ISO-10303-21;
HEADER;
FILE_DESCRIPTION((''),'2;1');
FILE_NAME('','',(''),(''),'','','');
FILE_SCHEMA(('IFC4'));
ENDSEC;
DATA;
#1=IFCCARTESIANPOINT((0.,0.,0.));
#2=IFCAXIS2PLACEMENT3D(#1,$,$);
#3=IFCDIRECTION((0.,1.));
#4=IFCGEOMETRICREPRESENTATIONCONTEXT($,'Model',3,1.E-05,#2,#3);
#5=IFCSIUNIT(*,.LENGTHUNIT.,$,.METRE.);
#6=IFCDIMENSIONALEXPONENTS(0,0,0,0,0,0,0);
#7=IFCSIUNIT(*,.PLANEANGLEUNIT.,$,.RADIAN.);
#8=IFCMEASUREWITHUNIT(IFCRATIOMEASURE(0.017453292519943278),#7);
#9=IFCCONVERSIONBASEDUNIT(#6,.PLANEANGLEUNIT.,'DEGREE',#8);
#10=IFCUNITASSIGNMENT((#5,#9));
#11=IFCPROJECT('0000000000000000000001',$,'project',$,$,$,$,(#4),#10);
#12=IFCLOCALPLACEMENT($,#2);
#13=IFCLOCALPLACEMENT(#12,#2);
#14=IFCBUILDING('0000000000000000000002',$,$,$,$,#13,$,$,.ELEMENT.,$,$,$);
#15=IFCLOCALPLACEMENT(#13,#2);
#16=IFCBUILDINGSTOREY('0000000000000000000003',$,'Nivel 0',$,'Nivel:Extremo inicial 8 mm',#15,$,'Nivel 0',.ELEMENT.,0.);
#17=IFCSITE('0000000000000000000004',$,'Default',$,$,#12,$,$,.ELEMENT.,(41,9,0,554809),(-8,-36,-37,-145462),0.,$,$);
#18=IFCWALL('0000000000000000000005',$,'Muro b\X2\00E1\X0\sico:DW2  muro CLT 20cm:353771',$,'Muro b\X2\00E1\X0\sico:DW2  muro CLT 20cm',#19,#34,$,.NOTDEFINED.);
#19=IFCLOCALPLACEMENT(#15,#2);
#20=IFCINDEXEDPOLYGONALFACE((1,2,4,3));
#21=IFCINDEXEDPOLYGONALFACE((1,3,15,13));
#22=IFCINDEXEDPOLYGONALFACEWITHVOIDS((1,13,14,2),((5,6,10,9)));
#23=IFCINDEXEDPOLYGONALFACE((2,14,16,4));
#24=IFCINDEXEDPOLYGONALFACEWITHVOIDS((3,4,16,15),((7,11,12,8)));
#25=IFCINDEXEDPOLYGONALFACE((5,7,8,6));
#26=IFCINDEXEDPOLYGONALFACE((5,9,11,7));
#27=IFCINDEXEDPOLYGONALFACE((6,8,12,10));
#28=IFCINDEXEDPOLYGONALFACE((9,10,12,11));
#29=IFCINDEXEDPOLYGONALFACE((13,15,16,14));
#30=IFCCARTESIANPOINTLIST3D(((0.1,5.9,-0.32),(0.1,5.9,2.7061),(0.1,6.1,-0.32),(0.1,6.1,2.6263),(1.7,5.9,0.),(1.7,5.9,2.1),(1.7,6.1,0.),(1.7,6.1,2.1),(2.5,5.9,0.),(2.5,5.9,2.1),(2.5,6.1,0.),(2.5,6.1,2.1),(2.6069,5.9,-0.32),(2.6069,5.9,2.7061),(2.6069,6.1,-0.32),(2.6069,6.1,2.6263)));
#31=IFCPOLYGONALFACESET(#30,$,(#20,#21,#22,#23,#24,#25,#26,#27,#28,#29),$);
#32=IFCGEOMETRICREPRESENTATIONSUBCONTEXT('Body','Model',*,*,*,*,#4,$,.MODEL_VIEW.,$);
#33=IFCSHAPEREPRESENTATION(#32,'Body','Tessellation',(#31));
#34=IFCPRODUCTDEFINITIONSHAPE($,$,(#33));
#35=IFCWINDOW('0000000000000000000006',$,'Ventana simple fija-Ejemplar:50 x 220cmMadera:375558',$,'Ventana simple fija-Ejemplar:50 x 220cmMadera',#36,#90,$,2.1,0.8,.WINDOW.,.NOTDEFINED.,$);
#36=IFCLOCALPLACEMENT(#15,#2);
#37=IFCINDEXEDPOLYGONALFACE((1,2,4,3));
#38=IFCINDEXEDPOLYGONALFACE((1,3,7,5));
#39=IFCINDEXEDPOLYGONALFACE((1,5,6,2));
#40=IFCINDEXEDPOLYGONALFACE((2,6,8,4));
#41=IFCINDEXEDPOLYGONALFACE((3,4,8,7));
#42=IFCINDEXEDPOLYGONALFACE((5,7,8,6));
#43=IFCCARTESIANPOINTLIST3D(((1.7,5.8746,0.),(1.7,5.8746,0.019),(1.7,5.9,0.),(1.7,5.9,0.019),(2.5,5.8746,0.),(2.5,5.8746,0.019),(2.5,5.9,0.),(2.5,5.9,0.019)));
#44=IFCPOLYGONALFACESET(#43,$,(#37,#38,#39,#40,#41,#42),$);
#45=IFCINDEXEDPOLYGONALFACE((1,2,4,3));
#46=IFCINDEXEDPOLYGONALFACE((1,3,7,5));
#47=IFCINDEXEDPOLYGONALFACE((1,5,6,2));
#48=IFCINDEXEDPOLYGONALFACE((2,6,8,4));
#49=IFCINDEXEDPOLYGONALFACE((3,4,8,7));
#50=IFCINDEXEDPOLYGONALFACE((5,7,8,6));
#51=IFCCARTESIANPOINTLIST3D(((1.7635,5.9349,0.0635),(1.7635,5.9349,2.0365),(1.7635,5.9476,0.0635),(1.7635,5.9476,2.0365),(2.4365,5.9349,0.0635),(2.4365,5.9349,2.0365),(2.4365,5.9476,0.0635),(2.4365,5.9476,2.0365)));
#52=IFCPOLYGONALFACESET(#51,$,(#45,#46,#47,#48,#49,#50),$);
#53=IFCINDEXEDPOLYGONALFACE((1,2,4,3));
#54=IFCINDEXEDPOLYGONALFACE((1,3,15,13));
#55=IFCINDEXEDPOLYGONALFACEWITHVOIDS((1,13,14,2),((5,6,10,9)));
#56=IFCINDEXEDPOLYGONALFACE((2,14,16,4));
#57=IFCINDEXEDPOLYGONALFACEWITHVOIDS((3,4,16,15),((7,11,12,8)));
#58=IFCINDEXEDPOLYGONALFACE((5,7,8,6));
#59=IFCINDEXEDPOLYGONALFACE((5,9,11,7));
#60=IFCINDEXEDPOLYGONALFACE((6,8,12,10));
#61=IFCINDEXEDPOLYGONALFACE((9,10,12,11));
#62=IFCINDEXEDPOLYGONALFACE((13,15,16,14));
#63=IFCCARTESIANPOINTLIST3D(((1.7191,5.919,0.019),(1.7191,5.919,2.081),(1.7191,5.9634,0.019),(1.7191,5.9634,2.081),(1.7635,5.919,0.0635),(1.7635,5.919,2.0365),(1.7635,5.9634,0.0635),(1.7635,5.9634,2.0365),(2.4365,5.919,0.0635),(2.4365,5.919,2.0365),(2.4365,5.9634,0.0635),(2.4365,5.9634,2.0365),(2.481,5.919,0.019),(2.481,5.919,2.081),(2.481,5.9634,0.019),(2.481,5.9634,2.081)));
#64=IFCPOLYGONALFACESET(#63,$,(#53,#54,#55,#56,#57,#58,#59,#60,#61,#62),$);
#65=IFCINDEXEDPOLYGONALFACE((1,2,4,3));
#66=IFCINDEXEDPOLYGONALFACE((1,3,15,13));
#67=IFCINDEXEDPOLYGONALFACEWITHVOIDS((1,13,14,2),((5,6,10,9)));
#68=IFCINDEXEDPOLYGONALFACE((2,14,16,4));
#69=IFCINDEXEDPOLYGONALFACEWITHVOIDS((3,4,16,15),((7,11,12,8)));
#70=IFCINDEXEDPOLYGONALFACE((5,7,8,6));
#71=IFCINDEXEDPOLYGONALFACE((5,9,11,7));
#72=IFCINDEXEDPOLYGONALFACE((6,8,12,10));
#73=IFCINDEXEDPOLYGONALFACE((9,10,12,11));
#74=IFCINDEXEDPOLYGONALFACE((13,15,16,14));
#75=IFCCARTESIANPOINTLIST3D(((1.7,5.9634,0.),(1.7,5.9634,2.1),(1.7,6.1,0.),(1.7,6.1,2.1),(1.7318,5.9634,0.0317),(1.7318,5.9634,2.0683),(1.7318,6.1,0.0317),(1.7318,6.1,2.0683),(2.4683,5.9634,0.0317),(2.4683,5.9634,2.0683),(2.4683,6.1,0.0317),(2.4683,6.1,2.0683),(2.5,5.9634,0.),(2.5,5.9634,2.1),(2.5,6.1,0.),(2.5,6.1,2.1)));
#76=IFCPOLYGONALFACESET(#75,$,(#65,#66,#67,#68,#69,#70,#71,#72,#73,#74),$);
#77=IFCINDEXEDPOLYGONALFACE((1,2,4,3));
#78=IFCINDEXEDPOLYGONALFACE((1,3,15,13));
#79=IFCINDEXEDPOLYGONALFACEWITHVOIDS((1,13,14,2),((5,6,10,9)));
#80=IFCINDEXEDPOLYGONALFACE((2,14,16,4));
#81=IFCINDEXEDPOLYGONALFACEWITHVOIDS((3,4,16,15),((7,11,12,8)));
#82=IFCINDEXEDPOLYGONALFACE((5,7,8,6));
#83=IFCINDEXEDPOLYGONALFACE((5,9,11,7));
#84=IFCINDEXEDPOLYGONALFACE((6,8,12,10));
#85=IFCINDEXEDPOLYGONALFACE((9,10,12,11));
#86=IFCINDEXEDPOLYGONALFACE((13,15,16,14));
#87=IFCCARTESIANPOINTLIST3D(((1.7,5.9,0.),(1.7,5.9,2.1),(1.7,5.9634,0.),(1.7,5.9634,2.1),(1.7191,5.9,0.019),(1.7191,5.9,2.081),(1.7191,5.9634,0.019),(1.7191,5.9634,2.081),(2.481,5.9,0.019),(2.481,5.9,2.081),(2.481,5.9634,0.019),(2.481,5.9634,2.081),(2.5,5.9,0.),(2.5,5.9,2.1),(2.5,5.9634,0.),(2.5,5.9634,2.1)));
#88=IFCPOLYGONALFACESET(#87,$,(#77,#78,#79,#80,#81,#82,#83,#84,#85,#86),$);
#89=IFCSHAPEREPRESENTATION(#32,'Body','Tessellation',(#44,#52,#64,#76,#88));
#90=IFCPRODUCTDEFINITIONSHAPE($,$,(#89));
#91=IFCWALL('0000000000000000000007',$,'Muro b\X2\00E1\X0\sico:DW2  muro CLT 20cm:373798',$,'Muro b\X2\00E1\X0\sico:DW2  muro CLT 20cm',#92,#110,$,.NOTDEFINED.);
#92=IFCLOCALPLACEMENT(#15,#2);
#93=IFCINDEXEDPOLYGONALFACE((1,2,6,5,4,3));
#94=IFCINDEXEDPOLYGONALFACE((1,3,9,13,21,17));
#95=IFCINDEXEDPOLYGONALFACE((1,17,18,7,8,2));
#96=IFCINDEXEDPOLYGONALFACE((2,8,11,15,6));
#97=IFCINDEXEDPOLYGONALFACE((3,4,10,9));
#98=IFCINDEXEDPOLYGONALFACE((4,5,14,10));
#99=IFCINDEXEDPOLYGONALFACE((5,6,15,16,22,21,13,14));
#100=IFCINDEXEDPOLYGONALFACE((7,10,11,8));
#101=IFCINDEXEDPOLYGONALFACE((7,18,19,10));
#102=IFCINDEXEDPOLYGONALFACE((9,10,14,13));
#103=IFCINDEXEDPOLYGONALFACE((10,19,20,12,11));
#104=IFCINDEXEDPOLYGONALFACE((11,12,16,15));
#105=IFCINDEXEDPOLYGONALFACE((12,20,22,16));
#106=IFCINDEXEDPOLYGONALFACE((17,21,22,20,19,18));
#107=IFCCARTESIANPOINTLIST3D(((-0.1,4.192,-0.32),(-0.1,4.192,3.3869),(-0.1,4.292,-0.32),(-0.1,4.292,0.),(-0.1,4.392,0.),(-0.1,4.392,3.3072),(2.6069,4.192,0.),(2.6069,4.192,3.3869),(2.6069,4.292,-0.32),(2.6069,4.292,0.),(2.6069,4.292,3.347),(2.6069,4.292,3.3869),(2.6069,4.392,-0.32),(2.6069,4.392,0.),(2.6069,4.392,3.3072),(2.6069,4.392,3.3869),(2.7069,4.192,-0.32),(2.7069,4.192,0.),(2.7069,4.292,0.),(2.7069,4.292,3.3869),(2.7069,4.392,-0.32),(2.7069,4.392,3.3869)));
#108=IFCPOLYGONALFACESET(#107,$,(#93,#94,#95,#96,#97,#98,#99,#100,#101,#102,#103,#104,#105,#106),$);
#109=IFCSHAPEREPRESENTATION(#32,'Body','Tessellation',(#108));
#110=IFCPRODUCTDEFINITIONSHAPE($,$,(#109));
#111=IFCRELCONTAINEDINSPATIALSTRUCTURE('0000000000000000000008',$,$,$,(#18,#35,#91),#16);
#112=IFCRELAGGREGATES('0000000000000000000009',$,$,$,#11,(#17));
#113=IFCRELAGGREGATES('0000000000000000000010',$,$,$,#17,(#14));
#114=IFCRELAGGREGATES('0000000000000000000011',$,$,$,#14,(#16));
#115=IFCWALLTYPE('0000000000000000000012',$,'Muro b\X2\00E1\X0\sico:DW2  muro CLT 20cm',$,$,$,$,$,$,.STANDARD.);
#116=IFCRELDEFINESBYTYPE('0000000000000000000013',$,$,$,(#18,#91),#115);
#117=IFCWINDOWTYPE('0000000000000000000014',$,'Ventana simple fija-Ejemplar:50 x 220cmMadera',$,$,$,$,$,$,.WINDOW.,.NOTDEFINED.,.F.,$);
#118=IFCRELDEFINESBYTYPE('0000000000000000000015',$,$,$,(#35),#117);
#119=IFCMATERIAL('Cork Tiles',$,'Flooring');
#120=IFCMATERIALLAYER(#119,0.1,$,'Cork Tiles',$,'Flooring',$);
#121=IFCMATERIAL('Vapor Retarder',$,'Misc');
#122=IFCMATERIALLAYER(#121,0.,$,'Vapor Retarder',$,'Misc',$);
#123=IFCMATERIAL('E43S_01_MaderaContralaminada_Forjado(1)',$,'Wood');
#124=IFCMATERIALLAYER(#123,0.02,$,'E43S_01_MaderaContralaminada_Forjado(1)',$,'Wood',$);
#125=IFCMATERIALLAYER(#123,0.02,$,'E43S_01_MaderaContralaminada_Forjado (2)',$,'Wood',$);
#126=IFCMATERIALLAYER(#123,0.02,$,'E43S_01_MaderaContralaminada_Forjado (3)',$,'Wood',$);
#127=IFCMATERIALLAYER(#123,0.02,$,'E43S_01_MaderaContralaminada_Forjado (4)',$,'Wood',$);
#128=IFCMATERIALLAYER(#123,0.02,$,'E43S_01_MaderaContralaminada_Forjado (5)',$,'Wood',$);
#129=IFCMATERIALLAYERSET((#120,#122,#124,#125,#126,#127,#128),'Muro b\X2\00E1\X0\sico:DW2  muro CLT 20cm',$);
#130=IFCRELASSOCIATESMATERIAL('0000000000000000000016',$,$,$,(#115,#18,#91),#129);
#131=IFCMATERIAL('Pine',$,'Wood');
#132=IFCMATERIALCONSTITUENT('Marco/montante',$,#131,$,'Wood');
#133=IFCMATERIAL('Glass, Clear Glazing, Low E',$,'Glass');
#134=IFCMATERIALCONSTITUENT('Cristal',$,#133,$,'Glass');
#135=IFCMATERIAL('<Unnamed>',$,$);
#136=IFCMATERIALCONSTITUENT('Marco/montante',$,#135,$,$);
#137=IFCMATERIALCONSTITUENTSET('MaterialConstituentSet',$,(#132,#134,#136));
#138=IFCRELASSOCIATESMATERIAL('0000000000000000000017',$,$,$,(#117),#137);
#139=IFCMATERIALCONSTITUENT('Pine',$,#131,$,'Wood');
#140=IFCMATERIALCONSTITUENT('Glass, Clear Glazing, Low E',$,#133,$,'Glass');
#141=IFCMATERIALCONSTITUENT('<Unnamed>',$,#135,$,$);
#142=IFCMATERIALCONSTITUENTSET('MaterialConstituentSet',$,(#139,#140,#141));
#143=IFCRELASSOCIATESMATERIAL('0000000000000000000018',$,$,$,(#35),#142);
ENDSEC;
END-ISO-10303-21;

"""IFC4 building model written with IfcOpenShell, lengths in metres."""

from ifc_helpers import new_model, entity, si_unit, converted_unit, direction, frame, frame_2d, origin, origin_2d_with_axis, place, context, subcontext, project, spatial, polyline, rectangle, outline, extrude, clip, bounded_halfspace, source, transform, mapped, material, layer, layer_set, layer_usage, constituent, constituent_set, type_object, type_shapes, element, fill, save


model = new_model("IFC4")

# Units and contexts
model_context = context("Model", 3, precision=1e-05, world=origin(), true_north=direction((0.0, 1.0)))
body_context = subcontext(model_context, "Body", "Model", "MODEL_VIEW")
ifc_project = project(units=[si_unit("LENGTHUNIT", "METRE"), converted_unit("PLANEANGLEUNIT", "DEGREE", entity("IfcRatioMeasure", 0.017453292519943278), si_unit("PLANEANGLEUNIT", "RADIAN"), dimensions=[0, 0, 0, 0, 0, 0, 0])], contexts=[model_context])

# Site, building, storey
site_placement = place(None, origin())
site = spatial("IfcSite", under=ifc_project, at=site_placement, Name="Default", CompositionType="ELEMENT", RefLatitude=(41, 9, 0, 554809), RefLongitude=(-8, -36, -37, -145462), RefElevation=0.0)
building_placement = place(site_placement, origin())
building = spatial("IfcBuilding", under=site, at=building_placement, CompositionType="ELEMENT")
storey_placement = place(building_placement, origin())
storey = spatial("IfcBuildingStorey", under=building, at=storey_placement, Name="Nivel 0", ObjectType="Nivel:Extremo inicial 8 mm", LongName="Nivel 0", CompositionType="ELEMENT", Elevation=0.0)

# Shared definitions
ifc_material_1 = material(Name="E43S_01_MaderaContralaminada_Forjado(1)", Category="Wood")
ifc_material_2 = material(Name="Cork Tiles", Category="Flooring")

# Shared definitions
ifc_material_3 = material(Name="Vapor Retarder", Category="Misc")

# Wall, opening, window
ifc_layer_1 = layer(ifc_material_2, 0.1, Name="Cork Tiles", Category="Flooring")
ifc_layer_2 = layer(ifc_material_3, 0.0, Name="Vapor Retarder", Category="Misc")
ifc_layer_3 = layer(ifc_material_1, 0.02, Name="E43S_01_MaderaContralaminada_Forjado(1)", Category="Wood")
ifc_layer_4 = layer(ifc_material_1, 0.02, Name="E43S_01_MaderaContralaminada_Forjado (2)", Category="Wood")
ifc_layer_5 = layer(ifc_material_1, 0.02, Name="E43S_01_MaderaContralaminada_Forjado (3)", Category="Wood")
ifc_layer_6 = layer(ifc_material_1, 0.02, Name="E43S_01_MaderaContralaminada_Forjado (4)", Category="Wood")
ifc_layer_7 = layer(ifc_material_1, 0.02, Name="E43S_01_MaderaContralaminada_Forjado (5)", Category="Wood")
ifc_layer_set_1 = layer_set([ifc_layer_1, ifc_layer_2, ifc_layer_3, ifc_layer_4, ifc_layer_5, ifc_layer_6, ifc_layer_7], Name="Muro básico:DW2  muro CLT 20cm")
ifc_layer_usage_1 = layer_usage(ifc_layer_set_1, "AXIS2", "NEGATIVE", 0.1)
wall_type_1 = type_object("IfcWallType", Name="Muro básico:DW2  muro CLT 20cm", PredefinedType="STANDARD", material=ifc_layer_set_1)
wall_1_placement = place(storey_placement, frame((0.1, 6.0, -0.32)))
wall_1 = element("IfcWall", 1, at=wall_1_placement, inside=storey, type_object=wall_type_1, material=ifc_layer_usage_1, Name="Muro básico:DW2  muro CLT 20cm:353771", ObjectType="Muro básico:DW2  muro CLT 20cm", PredefinedType="NOTDEFINED", context=body_context, shape_type="Clipping", body=[
    clip(clip(extrude(rectangle(XDim=2.5069, YDim=0.2, at=frame_2d((1.2535, 0.0), x_axis=(1.0, 0.0))), origin(), (0.0, 0.0, 1.0), 3.0261), bounded_halfspace(frame((0.0, -0.1, 3.0261), z_axis=(0.0, 0.370288, 0.928917), x_axis=(-1.0, 0.0, 0.0)), False, frame((0.0, -0.1, 3.0261)), polyline([(0.0, 0.0), (2.5069, 0.0), (2.5069, 0.2), (0.0, 0.2), (0.0, 0.0)]))), bounded_halfspace(frame((2.6069, 0.1, 0.32), z_axis=(0.0, 0.0, 1.0), x_axis=(-1.0, 0.0, 0.0)), False, frame((2.6069, 0.1, 0.32)), polyline([(0.0, 0.0), (-0.1, 0.0), (-0.1, -0.1), (0.0, -0.1), (0.0, 0.0)]))),
])
opening_1_placement = place(wall_1_placement, frame((2.4, 0.1, 0.32)))
opening_1 = element("IfcOpeningElement", 2, at=opening_1_placement, cuts=wall_1, PredefinedType="OPENING", context=body_context, shape_type="SweptSolid", body=[
    extrude(rectangle(XDim=2.1, YDim=0.8, at=frame_2d((1.05, 0.4), x_axis=(-1.0, 0.0))), frame((0.0, 0.0, 0.0), z_axis=(0.0, -1.0, 0.0), x_axis=(0.0, 0.0, 1.0)), (0.0, 0.0, 1.0), 0.2),
])
ifc_material_4 = material(Name="Pine", Category="Wood")
ifc_constituent_1 = constituent(ifc_material_4, Name="Pine", Category="Wood")
ifc_material_5 = material(Name="Glass, Clear Glazing, Low E", Category="Glass")
ifc_constituent_2 = constituent(ifc_material_5, Name="Glass, Clear Glazing, Low E", Category="Glass")
ifc_material_6 = material(Name="<Unnamed>")
ifc_constituent_3 = constituent(ifc_material_6, Name="<Unnamed>")
ifc_constituent_set_1 = constituent_set(constituents=[ifc_constituent_1, ifc_constituent_2, ifc_constituent_3], Name="MaterialConstituentSet")
ifc_constituent_4 = constituent(ifc_material_4, Name="Marco/montante", Category="Wood")
ifc_constituent_5 = constituent(ifc_material_5, Name="Cristal", Category="Glass")
ifc_constituent_6 = constituent(ifc_material_6, Name="Marco/montante")
ifc_constituent_set_2 = constituent_set(constituents=[ifc_constituent_4, ifc_constituent_5, ifc_constituent_6], Name="MaterialConstituentSet")
window_type_1 = type_object("IfcWindowType", Name="Ventana simple fija-Ejemplar:50 x 220cmMadera", ParameterTakesPrecedence=False, PartitioningType="NOTDEFINED", PredefinedType="WINDOW", material=ifc_constituent_set_2)
shared_shape_1 = source(origin(), body_context, "Body", "SweptSolid", [
    extrude(rectangle(XDim=0.8, YDim=0.0254, at=origin_2d_with_axis()), frame((0.4762, 0.2127, 0.0), z_axis=(0.0, 0.0, 1.0), x_axis=(-1.0, 0.0, 0.0)), (0.0, 0.0, 1.0), 0.019),
    extrude(rectangle(XDim=0.673, YDim=0.0127, at=frame_2d((0.0, 0.0), x_axis=(1.0, 0.0))), frame((0.4762, 0.1588, 0.0635)), (0.0, 0.0, 1.0), 1.973),
    extrude(outline(polyline([(-0.3809, -1.031), (0.3809, -1.031), (0.3809, 1.031), (-0.3809, 1.031), (-0.3809, -1.031)]), holes=[polyline([(-0.3365, -0.9865), (-0.3365, 0.9865), (0.3365, 0.9865), (0.3365, -0.9865), (-0.3365, -0.9865)])]), frame((0.4762, 0.181, 1.05), z_axis=(0.0, -1.0, 0.0), x_axis=(-1.0, 0.0, 0.0)), (0.0, 0.0, 1.0), 0.0444),
    extrude(outline(polyline([(-0.4, -1.05), (0.4, -1.05), (0.4, 1.05), (-0.4, 1.05), (-0.4, -1.05)]), holes=[polyline([(-0.3683, -1.0183), (-0.3683, 1.0183), (0.3682, 1.0183), (0.3682, -1.0183), (-0.3683, -1.0183)])]), frame((0.4762, 0.1365, 1.05), z_axis=(0.0, -1.0, 0.0), x_axis=(-1.0, 0.0, 0.0)), (0.0, 0.0, 1.0), 0.1365),
    extrude(outline(polyline([(-1.05, -0.4), (1.05, -0.4), (1.05, 0.4), (-1.05, 0.4), (-1.05, -0.4)]), holes=[polyline([(-1.031, -0.3809), (-1.031, 0.381), (1.031, 0.381), (1.031, -0.3809), (-1.031, -0.3809)])]), frame((0.4762, 0.2, 1.05), z_axis=(0.0, -1.0, 0.0), x_axis=(0.0, 0.0, -1.0)), (0.0, 0.0, 1.0), 0.0635),
])
type_shapes(window_type_1, [shared_shape_1])
window_1_placement = place(opening_1_placement, frame((0.0762, 0.0, 0.0), z_axis=(0.0, 0.0, 1.0), x_axis=(-1.0, 0.0, 0.0)))
window_1 = element("IfcWindow", 3, at=window_1_placement, inside=storey, type_object=window_type_1, material=ifc_constituent_set_1, Name="Ventana simple fija-Ejemplar:50 x 220cmMadera:375558", ObjectType="Ventana simple fija-Ejemplar:50 x 220cmMadera", OverallHeight=2.1, OverallWidth=0.8, PartitioningType="NOTDEFINED", PredefinedType="WINDOW", context=body_context, shape_type="MappedRepresentation", body=[
    mapped(shared_shape_1, transform((0.0, 0.0, 0.0), scale=1.0)),
])
fill(opening_1, window_1)

# Wall
ifc_layer_usage_2 = layer_usage(ifc_layer_set_1, "AXIS2", "NEGATIVE", 0.1)
wall_2_placement = place(storey_placement, frame((2.7069, 4.292, -0.32), z_axis=(0.0, 0.0, 1.0), x_axis=(-1.0, 0.0, 0.0)))
element("IfcWall", 4, at=wall_2_placement, inside=storey, type_object=wall_type_1, material=ifc_layer_usage_2, Name="Muro básico:DW2  muro CLT 20cm:373798", ObjectType="Muro básico:DW2  muro CLT 20cm", PredefinedType="NOTDEFINED", context=body_context, shape_type="Clipping", body=[
    clip(clip(clip(extrude(rectangle(XDim=2.8069, YDim=0.2, at=frame_2d((1.4035, 0.0), x_axis=(-1.0, 0.0))), origin(), (0.0, 0.0, 1.0), 3.7069), bounded_halfspace(frame((0.1, -0.1, 3.6272), z_axis=(0.0, -0.370288, 0.928917), x_axis=(1.0, 0.0, 0.0)), False, frame((0.1, -0.1, 3.6272)), polyline([(0.0, 0.0), (2.5069, 0.0), (2.7069, 0.0), (2.7069, 0.2), (0.0, 0.2), (0.0, 0.0)]))), bounded_halfspace(frame((2.8069, -0.1, 0.32), z_axis=(0.0, 0.0, -1.0), x_axis=(0.0, 1.0, 0.0)), False, frame((2.8069, -0.1, 0.32)), polyline([(0.0, 0.0), (0.0, 0.1), (-0.1, 0.1), (-2.7069, 0.1), (-2.7069, 0.0), (-0.2, 0.0), (0.0, 0.0)]))), bounded_halfspace(frame((0.0, 0.0, 0.32)), False, frame((0.0, 0.0, 0.32)), polyline([(0.0, 0.0), (0.1, 0.0), (0.1, 0.1), (0.0, 0.1), (0.0, 0.0)]))),
])

save(model, "model.ifc")
